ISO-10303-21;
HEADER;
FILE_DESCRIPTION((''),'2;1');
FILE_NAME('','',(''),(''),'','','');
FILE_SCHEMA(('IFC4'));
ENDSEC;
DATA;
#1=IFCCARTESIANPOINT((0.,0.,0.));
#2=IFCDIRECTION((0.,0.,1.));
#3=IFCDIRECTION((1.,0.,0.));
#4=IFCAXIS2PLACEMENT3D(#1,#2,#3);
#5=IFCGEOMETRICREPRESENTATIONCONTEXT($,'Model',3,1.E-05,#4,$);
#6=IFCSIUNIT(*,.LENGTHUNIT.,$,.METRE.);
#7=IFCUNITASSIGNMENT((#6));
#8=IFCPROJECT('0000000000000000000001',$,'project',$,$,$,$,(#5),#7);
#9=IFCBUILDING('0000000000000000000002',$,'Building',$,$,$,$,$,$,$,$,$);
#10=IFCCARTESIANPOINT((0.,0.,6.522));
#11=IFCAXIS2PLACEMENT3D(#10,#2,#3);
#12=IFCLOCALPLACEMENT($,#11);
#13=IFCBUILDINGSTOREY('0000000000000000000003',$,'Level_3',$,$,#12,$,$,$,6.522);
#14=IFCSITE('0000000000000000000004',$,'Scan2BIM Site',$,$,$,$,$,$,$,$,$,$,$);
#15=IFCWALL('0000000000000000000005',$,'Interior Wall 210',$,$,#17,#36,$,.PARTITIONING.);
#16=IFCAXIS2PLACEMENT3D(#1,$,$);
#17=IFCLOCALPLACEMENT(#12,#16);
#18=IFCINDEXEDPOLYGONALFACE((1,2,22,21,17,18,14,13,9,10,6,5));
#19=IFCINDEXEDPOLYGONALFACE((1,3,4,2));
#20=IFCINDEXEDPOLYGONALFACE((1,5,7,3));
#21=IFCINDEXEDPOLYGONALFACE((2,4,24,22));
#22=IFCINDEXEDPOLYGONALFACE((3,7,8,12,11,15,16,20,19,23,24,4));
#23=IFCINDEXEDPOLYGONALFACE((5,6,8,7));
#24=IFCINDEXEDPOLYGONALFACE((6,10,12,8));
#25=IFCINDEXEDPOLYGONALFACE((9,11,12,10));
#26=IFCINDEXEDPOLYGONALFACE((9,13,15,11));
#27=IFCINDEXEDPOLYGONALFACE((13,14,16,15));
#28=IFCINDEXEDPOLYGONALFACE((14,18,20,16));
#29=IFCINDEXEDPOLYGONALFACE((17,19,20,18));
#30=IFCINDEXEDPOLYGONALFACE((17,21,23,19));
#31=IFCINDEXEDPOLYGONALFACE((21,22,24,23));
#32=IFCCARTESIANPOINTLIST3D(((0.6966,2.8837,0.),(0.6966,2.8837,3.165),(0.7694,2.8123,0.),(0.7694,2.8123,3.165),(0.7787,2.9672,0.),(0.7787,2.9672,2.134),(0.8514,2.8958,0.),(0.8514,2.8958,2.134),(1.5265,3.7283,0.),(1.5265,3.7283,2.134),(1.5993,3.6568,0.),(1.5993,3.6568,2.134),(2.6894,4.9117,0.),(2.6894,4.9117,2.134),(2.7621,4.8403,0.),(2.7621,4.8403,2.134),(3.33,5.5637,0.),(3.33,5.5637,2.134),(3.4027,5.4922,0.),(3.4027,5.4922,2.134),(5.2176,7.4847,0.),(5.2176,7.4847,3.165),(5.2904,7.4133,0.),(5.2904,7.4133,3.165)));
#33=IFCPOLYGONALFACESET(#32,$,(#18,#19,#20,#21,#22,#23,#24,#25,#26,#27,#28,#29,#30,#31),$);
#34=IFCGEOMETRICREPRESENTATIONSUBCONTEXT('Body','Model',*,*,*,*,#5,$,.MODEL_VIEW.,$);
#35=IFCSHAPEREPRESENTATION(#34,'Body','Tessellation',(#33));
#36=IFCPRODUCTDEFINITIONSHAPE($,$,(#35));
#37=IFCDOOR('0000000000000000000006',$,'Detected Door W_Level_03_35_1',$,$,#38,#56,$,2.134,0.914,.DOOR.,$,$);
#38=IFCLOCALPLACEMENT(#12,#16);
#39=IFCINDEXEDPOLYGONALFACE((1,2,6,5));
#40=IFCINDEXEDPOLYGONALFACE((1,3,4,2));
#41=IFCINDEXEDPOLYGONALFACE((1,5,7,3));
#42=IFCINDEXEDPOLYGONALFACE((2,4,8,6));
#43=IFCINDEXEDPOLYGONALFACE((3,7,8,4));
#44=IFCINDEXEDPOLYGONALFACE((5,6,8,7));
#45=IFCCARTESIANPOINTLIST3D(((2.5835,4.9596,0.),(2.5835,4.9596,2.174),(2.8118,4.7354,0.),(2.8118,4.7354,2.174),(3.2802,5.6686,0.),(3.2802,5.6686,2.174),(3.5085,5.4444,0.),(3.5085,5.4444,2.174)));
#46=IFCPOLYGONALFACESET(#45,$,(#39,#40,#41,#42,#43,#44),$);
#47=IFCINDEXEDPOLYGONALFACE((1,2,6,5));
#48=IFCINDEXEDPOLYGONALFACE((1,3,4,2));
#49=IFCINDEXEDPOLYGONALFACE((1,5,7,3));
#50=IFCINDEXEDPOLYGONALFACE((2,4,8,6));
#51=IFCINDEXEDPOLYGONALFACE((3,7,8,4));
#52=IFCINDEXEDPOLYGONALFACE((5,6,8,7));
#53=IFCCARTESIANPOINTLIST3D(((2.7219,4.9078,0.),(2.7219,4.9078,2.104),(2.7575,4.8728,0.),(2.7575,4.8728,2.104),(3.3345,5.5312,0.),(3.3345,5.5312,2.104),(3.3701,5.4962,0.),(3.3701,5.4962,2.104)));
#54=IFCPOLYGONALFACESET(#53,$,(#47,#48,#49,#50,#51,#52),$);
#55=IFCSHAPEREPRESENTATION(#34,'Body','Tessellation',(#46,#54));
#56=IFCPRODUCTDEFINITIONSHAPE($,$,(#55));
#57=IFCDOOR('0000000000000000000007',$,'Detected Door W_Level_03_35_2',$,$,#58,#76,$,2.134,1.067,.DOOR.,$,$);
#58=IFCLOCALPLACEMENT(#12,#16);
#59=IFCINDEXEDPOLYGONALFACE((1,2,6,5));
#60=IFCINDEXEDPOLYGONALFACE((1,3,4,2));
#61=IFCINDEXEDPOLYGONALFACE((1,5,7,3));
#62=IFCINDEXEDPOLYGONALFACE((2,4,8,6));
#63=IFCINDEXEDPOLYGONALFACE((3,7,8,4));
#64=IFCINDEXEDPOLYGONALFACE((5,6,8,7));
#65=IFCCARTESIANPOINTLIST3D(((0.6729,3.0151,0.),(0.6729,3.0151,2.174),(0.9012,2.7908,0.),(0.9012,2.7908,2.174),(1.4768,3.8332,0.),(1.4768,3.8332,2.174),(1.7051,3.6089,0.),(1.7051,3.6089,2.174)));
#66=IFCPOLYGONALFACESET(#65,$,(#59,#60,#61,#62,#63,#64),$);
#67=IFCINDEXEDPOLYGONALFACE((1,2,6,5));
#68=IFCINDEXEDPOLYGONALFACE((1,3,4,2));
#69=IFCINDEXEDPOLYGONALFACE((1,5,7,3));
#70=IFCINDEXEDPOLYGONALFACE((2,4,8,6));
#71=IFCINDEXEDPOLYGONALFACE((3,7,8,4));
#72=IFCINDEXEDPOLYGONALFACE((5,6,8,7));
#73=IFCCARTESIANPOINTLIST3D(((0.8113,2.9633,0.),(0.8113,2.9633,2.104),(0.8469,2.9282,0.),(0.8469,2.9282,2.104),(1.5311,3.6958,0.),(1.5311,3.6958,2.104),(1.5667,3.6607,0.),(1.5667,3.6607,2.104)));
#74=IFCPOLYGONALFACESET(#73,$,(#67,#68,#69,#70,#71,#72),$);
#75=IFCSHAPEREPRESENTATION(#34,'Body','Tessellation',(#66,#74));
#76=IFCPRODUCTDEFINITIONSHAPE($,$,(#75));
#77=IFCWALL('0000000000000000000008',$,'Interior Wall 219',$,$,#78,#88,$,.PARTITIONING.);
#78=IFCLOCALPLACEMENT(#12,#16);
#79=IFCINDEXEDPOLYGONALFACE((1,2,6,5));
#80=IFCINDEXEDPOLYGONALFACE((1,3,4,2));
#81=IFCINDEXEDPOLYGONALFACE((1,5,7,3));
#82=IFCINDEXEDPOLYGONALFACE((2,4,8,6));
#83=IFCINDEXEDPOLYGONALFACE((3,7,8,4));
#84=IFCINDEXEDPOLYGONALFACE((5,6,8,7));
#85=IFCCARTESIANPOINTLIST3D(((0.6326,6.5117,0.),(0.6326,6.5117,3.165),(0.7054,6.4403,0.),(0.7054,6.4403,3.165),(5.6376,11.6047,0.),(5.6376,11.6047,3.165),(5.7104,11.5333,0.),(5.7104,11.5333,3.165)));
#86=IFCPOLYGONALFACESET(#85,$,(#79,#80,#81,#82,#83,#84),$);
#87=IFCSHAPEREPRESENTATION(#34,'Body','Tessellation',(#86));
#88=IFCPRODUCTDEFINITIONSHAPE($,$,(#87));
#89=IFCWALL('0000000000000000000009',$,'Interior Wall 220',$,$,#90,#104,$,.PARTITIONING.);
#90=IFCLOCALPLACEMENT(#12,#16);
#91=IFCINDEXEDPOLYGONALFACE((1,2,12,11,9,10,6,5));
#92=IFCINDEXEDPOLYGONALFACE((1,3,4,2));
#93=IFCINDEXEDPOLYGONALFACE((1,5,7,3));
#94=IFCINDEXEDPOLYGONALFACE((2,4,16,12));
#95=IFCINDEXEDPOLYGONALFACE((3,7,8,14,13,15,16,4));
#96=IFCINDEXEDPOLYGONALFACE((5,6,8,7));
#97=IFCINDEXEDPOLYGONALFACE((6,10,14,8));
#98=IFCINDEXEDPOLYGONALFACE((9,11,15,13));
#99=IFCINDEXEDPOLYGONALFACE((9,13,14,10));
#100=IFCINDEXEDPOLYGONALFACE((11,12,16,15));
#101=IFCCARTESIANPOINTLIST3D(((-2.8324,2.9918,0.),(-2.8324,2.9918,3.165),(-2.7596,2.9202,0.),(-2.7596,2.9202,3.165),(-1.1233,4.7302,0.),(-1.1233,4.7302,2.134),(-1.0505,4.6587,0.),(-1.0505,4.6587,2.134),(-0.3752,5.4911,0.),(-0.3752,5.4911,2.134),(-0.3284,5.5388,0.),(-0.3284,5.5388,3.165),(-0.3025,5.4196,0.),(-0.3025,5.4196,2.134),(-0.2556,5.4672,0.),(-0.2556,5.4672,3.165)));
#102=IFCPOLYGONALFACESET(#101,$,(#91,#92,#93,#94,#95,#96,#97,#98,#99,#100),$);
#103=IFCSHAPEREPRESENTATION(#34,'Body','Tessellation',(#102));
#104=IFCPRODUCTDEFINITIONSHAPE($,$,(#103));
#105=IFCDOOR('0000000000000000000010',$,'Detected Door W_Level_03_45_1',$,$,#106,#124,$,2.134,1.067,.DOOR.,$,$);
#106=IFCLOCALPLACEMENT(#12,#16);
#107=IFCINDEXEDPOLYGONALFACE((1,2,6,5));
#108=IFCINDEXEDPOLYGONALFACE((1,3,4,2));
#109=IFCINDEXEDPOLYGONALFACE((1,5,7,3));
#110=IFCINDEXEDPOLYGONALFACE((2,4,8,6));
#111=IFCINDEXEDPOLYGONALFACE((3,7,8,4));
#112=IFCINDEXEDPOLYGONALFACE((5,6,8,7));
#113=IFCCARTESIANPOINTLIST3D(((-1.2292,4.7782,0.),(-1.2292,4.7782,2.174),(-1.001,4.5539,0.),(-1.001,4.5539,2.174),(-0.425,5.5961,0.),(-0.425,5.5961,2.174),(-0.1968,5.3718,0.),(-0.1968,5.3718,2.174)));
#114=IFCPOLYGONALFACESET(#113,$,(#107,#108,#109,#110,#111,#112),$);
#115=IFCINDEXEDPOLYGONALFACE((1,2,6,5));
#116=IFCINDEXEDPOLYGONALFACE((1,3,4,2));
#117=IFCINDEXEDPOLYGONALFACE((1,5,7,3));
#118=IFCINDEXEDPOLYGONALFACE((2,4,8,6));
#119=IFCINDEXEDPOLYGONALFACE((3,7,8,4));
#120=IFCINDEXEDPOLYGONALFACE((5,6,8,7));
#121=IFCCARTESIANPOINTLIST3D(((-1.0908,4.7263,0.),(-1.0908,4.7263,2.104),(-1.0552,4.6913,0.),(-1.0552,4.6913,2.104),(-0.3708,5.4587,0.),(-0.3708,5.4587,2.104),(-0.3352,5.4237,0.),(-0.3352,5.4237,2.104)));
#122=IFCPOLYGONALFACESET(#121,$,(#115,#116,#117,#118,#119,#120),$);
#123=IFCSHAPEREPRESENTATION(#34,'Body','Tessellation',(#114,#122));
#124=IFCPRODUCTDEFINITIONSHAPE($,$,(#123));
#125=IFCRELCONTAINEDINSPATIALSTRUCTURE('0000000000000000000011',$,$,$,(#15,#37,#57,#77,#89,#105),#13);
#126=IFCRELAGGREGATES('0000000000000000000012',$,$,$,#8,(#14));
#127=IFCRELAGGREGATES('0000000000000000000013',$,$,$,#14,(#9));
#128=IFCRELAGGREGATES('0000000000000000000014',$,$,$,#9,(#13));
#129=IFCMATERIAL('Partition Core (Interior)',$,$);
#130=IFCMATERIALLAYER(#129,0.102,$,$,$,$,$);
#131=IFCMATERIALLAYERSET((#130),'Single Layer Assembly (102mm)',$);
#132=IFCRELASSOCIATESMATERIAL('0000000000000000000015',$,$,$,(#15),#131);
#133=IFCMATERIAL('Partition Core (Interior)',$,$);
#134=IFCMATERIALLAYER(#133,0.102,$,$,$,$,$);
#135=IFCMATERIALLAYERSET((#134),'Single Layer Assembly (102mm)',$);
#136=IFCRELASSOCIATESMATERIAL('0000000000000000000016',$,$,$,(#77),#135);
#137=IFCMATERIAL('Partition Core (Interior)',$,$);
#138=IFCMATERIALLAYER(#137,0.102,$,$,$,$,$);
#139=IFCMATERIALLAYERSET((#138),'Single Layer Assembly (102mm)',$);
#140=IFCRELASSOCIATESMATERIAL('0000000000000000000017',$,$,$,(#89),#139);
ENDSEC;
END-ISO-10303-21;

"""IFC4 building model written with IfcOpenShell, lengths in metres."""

from ifc_helpers import new_model, si_unit, frame, origin, origin_with_axes, place, context, subcontext, project, spatial, rectangle, extrude, material, layer, layer_set, element, fill, save


model = new_model("IFC4")

# Units and contexts
model_context = context("Model", 3, precision=1e-05, world=origin_with_axes())
body_context = subcontext(model_context, "Body", "Model", "MODEL_VIEW")
ifc_project = project(units=[si_unit("LENGTHUNIT", "METRE")], contexts=[model_context])

# Site, building, storey
site = spatial("IfcSite", under=ifc_project, Name="Scan2BIM Site")
building = spatial("IfcBuilding", under=site, Name="Building")
storey_placement = place(None, frame((0.0, 0.0, 6.522), z_axis=(0.0, 0.0, 1.0), x_axis=(1.0, 0.0, 0.0)))
storey = spatial("IfcBuildingStorey", under=building, at=storey_placement, Name="Level_3", Elevation=6.522)

# Wall, openings, doors
ifc_material_1 = material(Name="Partition Core (Interior)")
ifc_layer_1 = layer(ifc_material_1, 0.102)
ifc_layer_set_1 = layer_set([ifc_layer_1], Name="Single Layer Assembly (102mm)")
wall_1_placement = place(storey_placement, frame((2.9935, 5.1485, 0.0), z_axis=(0.0, 0.0, 1.0), x_axis=(-0.700878, -0.713281, 0.0)))
wall_1 = element("IfcWall", 1, at=wall_1_placement, inside=storey, material=ifc_layer_set_1, Name="Interior Wall 210", PredefinedType="PARTITIONING", context=body_context, shape_type="SweptSolid", body=[
    extrude(rectangle(XDim=6.4505, YDim=0.102), origin(), (0.0, 0.0, 1.0), 3.165),
])
opening_1_placement = place(None, frame((3.046, 5.202, 6.522), z_axis=(0.0, 0.0, 1.0), x_axis=(-0.700878, -0.713281, 0.0)))
opening_1 = element("IfcOpeningElement", 2, at=opening_1_placement, cuts=wall_1, PredefinedType="OPENING", context=body_context, shape_type="SweptSolid", body=[
    extrude(rectangle(XDim=0.914, YDim=0.202), origin(), (0.0, 0.0, 1.0), 2.134),
])
opening_2_placement = place(None, frame((1.189, 3.312, 6.522), z_axis=(0.0, 0.0, 1.0), x_axis=(-0.700878, -0.713281, 0.0)))
opening_2 = element("IfcOpeningElement", 3, at=opening_2_placement, cuts=wall_1, PredefinedType="OPENING", context=body_context, shape_type="SweptSolid", body=[
    extrude(rectangle(XDim=1.067, YDim=0.202), origin(), (0.0, 0.0, 1.0), 2.134),
])
door_1_placement = place(opening_1_placement, frame((0.0, 0.0, 0.0), z_axis=(0.0, 0.0, 1.0), x_axis=(1.0, 0.0, 0.0)))
door_1 = element("IfcDoor", 4, at=door_1_placement, inside=storey, Name="Detected Door W_Level_03_35_1", OverallHeight=2.134, OverallWidth=0.914, PredefinedType="DOOR", context=body_context, shape_type="SweptSolid", body=[
    extrude(rectangle(XDim=0.994, YDim=0.32), origin(), (0.0, 0.0, 1.0), 2.174),
    extrude(rectangle(XDim=0.874, YDim=0.05), origin(), (0.0, 0.0, 1.0), 2.104),
])
fill(opening_1, door_1)
door_2_placement = place(opening_2_placement, frame((0.0, 0.0, 0.0), z_axis=(0.0, 0.0, 1.0), x_axis=(1.0, 0.0, 0.0)))
door_2 = element("IfcDoor", 5, at=door_2_placement, inside=storey, Name="Detected Door W_Level_03_35_2", OverallHeight=2.134, OverallWidth=1.067, PredefinedType="DOOR", context=body_context, shape_type="SweptSolid", body=[
    extrude(rectangle(XDim=1.147, YDim=0.32), origin(), (0.0, 0.0, 1.0), 2.174),
    extrude(rectangle(XDim=1.027, YDim=0.05), origin(), (0.0, 0.0, 1.0), 2.104),
])
fill(opening_2, door_2)

# Wall
ifc_material_2 = material(Name="Partition Core (Interior)")
ifc_layer_2 = layer(ifc_material_2, 0.102)
ifc_layer_set_2 = layer_set([ifc_layer_2], Name="Single Layer Assembly (102mm)")
wall_2_placement = place(storey_placement, frame((3.1715, 9.0225, 0.0), z_axis=(0.0, 0.0, 1.0), x_axis=(-0.700918, -0.713242, 0.0)))
element("IfcWall", 6, at=wall_2_placement, inside=storey, material=ifc_layer_set_2, Name="Interior Wall 219", PredefinedType="PARTITIONING", context=body_context, shape_type="SweptSolid", body=[
    extrude(rectangle(XDim=7.1406, YDim=0.102), origin(), (0.0, 0.0, 1.0), 3.165),
])

# Wall, opening, door
ifc_material_3 = material(Name="Partition Core (Interior)")
ifc_layer_3 = layer(ifc_material_3, 0.102)
ifc_layer_set_3 = layer_set([ifc_layer_3], Name="Single Layer Assembly (102mm)")
wall_3_placement = place(storey_placement, frame((-1.544, 4.2295, 0.0), z_axis=(0.0, 0.0, 1.0), x_axis=(-0.701062, -0.713101, 0.0)))
wall_3 = element("IfcWall", 7, at=wall_3_placement, inside=storey, material=ifc_layer_set_3, Name="Interior Wall 220", PredefinedType="PARTITIONING", context=body_context, shape_type="SweptSolid", body=[
    extrude(rectangle(XDim=3.5717, YDim=0.102), origin(), (0.0, 0.0, 1.0), 3.165),
])
opening_3_placement = place(None, frame((-0.713, 5.075, 6.522), z_axis=(0.0, 0.0, 1.0), x_axis=(-0.701062, -0.713101, 0.0)))
opening_3 = element("IfcOpeningElement", 8, at=opening_3_placement, cuts=wall_3, PredefinedType="OPENING", context=body_context, shape_type="SweptSolid", body=[
    extrude(rectangle(XDim=1.067, YDim=0.202), origin(), (0.0, 0.0, 1.0), 2.134),
])
door_3_placement = place(opening_3_placement, frame((0.0, 0.0, 0.0), z_axis=(0.0, 0.0, 1.0), x_axis=(1.0, 0.0, 0.0)))
door_3 = element("IfcDoor", 9, at=door_3_placement, inside=storey, Name="Detected Door W_Level_03_45_1", OverallHeight=2.134, OverallWidth=1.067, PredefinedType="DOOR", context=body_context, shape_type="SweptSolid", body=[
    extrude(rectangle(XDim=1.147, YDim=0.32), origin(), (0.0, 0.0, 1.0), 2.174),
    extrude(rectangle(XDim=1.027, YDim=0.05), origin(), (0.0, 0.0, 1.0), 2.104),
])
fill(opening_3, door_3)

save(model, "model.ifc")
